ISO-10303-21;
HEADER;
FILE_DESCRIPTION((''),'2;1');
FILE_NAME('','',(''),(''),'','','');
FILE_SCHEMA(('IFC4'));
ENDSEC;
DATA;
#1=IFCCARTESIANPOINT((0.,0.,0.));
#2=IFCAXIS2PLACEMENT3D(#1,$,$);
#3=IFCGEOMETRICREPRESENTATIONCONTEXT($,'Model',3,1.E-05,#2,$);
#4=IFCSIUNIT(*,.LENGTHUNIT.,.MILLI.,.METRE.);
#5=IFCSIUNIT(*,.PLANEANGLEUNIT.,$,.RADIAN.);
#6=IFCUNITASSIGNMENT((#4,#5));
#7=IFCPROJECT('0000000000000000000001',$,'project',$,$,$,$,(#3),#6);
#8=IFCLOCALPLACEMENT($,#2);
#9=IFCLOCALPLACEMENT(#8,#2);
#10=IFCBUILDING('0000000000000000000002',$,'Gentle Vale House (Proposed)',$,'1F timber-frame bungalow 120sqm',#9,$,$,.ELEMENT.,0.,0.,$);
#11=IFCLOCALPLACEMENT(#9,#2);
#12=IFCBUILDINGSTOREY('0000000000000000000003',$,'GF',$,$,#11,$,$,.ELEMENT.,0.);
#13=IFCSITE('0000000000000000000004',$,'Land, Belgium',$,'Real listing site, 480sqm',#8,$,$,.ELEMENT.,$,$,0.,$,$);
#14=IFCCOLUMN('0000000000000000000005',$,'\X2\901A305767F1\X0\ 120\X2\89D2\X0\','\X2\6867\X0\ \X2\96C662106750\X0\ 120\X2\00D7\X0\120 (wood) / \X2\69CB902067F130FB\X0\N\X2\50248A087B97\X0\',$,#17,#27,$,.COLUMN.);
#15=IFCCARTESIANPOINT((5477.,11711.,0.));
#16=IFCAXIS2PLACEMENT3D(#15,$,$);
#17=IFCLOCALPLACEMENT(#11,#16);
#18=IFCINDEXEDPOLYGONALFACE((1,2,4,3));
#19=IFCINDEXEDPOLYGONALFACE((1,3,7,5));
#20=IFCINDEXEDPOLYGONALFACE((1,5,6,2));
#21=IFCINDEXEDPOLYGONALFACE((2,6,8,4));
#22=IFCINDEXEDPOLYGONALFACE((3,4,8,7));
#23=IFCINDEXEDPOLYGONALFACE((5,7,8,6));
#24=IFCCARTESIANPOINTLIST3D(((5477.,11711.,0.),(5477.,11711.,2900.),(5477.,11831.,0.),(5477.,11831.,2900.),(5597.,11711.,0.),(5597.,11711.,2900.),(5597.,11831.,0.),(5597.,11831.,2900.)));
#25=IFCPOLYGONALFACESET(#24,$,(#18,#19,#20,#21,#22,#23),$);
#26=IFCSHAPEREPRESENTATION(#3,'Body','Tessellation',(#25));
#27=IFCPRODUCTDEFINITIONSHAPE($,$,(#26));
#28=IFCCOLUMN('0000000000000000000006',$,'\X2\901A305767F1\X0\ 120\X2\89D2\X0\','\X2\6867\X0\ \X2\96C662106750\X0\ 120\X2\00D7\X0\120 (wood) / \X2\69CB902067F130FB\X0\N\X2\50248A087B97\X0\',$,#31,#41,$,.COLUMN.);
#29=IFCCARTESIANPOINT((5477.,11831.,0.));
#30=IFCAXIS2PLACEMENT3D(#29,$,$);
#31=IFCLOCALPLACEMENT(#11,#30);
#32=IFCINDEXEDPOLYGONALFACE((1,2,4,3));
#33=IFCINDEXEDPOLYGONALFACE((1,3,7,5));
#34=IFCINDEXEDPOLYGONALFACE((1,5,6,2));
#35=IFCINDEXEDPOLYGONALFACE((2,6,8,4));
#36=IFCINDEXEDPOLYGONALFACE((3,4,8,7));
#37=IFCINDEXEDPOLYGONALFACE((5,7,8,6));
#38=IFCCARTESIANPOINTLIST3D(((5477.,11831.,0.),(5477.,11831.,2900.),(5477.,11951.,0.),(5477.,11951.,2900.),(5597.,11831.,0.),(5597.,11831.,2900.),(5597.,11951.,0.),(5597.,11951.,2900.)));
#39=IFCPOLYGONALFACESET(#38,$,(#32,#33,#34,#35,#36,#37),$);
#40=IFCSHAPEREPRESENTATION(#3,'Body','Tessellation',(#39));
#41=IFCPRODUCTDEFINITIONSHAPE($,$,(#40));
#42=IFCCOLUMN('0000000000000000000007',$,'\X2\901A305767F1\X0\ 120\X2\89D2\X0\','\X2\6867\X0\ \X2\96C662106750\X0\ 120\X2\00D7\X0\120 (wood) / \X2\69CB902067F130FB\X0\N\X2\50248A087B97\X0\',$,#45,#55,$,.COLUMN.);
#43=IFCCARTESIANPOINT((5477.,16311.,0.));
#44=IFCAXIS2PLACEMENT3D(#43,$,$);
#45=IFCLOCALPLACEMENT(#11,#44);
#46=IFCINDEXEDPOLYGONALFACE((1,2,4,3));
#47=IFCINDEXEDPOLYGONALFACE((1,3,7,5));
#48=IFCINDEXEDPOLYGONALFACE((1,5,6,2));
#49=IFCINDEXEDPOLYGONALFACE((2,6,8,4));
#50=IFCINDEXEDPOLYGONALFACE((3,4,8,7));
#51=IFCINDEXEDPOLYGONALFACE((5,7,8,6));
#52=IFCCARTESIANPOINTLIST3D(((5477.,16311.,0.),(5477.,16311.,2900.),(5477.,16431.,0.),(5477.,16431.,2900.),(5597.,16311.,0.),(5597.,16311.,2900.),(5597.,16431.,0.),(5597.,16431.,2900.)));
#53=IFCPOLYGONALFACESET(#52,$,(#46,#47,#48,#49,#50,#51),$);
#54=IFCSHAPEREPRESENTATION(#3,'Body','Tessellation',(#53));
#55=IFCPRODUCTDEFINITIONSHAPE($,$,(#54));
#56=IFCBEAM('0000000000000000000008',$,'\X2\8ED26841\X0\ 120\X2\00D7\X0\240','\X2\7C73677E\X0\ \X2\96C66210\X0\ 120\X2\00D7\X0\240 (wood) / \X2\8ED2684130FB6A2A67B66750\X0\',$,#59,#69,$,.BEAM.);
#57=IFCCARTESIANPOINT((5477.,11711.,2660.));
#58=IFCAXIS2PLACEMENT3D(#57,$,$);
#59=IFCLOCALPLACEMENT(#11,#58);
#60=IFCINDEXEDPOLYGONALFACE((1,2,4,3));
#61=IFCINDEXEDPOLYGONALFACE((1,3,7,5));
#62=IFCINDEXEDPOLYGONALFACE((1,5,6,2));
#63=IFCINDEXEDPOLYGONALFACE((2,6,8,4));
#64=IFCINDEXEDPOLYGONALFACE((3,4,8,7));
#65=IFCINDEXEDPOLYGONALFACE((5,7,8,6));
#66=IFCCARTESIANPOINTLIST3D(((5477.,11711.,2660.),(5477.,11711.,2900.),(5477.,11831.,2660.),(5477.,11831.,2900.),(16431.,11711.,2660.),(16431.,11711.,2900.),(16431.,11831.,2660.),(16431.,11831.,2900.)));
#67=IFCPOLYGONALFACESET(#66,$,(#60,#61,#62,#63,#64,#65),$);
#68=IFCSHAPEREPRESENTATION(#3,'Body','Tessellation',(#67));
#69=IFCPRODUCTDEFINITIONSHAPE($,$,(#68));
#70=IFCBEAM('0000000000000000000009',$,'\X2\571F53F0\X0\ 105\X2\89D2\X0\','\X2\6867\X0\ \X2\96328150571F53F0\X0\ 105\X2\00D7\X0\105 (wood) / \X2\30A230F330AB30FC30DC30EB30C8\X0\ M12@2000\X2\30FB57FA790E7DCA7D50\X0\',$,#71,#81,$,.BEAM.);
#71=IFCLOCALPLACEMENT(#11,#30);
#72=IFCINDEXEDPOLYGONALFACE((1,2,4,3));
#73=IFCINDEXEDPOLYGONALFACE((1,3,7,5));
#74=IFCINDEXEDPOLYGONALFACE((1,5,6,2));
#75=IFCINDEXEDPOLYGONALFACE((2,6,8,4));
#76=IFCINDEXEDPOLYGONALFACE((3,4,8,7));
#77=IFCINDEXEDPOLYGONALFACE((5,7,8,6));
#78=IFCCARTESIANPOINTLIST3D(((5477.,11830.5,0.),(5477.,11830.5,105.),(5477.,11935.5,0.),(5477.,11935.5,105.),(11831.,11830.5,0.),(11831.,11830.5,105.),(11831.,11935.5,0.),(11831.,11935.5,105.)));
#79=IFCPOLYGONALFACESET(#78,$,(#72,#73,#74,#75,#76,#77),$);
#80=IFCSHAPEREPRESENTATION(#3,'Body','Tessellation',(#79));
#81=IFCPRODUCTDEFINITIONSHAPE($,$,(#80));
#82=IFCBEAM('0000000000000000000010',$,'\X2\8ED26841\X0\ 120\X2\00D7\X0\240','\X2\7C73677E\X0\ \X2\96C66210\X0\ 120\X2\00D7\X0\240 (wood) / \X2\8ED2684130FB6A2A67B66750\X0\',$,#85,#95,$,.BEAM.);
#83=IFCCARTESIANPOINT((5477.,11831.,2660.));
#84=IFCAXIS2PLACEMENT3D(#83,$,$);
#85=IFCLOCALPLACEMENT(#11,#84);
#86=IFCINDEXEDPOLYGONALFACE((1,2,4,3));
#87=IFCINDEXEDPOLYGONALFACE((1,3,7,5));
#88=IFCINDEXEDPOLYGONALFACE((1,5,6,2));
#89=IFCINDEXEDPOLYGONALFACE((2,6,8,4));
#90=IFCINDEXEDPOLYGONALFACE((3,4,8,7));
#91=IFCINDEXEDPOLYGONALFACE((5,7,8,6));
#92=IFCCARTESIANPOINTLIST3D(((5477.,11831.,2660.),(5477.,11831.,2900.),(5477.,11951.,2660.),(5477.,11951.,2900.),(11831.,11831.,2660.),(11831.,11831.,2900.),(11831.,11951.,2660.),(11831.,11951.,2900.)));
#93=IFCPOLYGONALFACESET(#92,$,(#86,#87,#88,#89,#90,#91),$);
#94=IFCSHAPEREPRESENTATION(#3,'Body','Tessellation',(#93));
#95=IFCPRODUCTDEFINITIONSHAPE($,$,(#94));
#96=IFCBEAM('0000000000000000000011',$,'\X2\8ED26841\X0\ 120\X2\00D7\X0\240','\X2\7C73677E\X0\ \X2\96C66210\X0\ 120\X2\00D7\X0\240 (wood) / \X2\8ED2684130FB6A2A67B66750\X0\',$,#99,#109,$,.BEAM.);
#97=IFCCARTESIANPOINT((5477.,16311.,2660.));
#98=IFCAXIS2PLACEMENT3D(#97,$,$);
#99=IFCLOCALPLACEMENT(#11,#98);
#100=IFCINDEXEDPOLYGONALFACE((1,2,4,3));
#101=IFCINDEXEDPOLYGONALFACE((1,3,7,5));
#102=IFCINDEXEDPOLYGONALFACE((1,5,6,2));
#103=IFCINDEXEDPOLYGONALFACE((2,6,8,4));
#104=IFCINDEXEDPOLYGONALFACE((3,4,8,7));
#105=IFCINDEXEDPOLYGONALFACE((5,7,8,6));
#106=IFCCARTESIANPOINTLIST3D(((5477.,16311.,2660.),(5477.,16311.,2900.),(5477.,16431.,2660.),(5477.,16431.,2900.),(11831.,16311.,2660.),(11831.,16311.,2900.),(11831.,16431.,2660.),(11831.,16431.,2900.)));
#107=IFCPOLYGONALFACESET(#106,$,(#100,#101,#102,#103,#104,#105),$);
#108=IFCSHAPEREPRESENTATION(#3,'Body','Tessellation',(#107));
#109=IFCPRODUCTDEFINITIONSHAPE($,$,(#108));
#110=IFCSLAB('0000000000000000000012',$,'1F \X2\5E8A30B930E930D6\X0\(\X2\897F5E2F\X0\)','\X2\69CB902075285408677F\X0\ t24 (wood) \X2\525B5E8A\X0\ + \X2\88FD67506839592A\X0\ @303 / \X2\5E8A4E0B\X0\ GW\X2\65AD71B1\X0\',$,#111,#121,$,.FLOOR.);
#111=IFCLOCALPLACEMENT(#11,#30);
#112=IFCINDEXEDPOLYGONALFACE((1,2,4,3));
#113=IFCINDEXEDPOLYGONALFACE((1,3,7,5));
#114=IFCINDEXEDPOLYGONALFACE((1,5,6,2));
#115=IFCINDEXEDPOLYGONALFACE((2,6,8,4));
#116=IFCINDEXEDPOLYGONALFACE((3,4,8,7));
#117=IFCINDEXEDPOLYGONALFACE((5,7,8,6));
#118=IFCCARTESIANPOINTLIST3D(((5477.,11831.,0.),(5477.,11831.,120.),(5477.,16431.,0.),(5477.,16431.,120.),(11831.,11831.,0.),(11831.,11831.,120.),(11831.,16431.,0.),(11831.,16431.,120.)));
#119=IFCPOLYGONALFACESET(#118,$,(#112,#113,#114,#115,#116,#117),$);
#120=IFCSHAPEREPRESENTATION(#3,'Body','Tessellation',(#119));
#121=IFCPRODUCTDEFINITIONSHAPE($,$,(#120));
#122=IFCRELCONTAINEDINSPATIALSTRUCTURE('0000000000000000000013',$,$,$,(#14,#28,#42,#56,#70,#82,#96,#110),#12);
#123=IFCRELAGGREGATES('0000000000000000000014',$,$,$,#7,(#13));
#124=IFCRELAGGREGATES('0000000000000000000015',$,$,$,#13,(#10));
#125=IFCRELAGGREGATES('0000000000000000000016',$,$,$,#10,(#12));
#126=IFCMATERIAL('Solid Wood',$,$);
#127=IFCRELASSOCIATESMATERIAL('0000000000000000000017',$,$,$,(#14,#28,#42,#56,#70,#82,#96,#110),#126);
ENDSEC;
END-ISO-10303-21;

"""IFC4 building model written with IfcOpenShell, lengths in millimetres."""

from ifc_helpers import new_model, si_unit, frame, frame_2d, origin, place, context, project, spatial, rectangle, extrude, material, element, save


model = new_model("IFC4")

# Units and contexts
model_context = context("Model", 3, precision=1e-05, world=origin())
ifc_project = project(units=[si_unit("LENGTHUNIT", "METRE", prefix="MILLI"), si_unit("PLANEANGLEUNIT", "RADIAN")], contexts=[model_context])

# Site, building, storey
site_placement = place(None, origin())
site = spatial("IfcSite", under=ifc_project, at=site_placement, Name="Land, Belgium", ObjectType="Real listing site, 480sqm", CompositionType="ELEMENT", RefElevation=0.0)
building_placement = place(site_placement, origin())
building = spatial("IfcBuilding", under=site, at=building_placement, Name="Gentle Vale House (Proposed)", ObjectType="1F timber-frame bungalow 120sqm", CompositionType="ELEMENT", ElevationOfRefHeight=0.0, ElevationOfTerrain=0.0)
storey_placement = place(building_placement, origin())
storey = spatial("IfcBuildingStorey", under=building, at=storey_placement, Name="GF", CompositionType="ELEMENT", Elevation=0.0)

# Columns
ifc_material_1 = material(Name="Solid Wood")
column_1_placement = place(storey_placement, frame((5477.0, 11711.0, 0.0)))
element("IfcColumn", 1, at=column_1_placement, inside=storey, material=ifc_material_1, Name="通し柱 120角", Description="桧 集成材 120×120 (wood) / 構造柱・N値計算", PredefinedType="COLUMN", context=model_context, shape_type="SweptSolid", body=[
    extrude(rectangle(XDim=120.0, YDim=120.0, at=frame_2d((60.0, 60.0))), frame((5477.0, 11711.0, 0.0)), (0.0, 0.0, 1.0), 2900.0),
])
column_2_placement = place(storey_placement, frame((5477.0, 11831.0, 0.0)))
element("IfcColumn", 2, at=column_2_placement, inside=storey, material=ifc_material_1, Name="通し柱 120角", Description="桧 集成材 120×120 (wood) / 構造柱・N値計算", PredefinedType="COLUMN", context=model_context, shape_type="SweptSolid", body=[
    extrude(rectangle(XDim=120.0, YDim=120.0, at=frame_2d((60.0, 60.0))), frame((5477.0, 11831.0, 0.0)), (0.0, 0.0, 1.0), 2900.0),
])
column_3_placement = place(storey_placement, frame((5477.0, 16311.0, 0.0)))
element("IfcColumn", 3, at=column_3_placement, inside=storey, material=ifc_material_1, Name="通し柱 120角", Description="桧 集成材 120×120 (wood) / 構造柱・N値計算", PredefinedType="COLUMN", context=model_context, shape_type="SweptSolid", body=[
    extrude(rectangle(XDim=120.0, YDim=120.0, at=frame_2d((60.0, 60.0))), frame((5477.0, 16311.0, 0.0)), (0.0, 0.0, 1.0), 2900.0),
])

# Beams
beam_1_placement = place(storey_placement, frame((5477.0, 11711.0, 2660.0)))
element("IfcBeam", 4, at=beam_1_placement, inside=storey, material=ifc_material_1, Name="軒桁 120×240", Description="米松 集成 120×240 (wood) / 軒桁・横架材", PredefinedType="BEAM", context=model_context, shape_type="SweptSolid", body=[
    extrude(rectangle(XDim=10954.0, YDim=120.0, at=frame_2d((5477.0, 60.0))), frame((5477.0, 11711.0, 2660.0)), (0.0, 0.0, 1.0), 240.0),
])
beam_2_placement = place(storey_placement, frame((5477.0, 11831.0, 0.0)))
element("IfcBeam", 5, at=beam_2_placement, inside=storey, material=ifc_material_1, Name="土台 105角", Description="桧 防腐土台 105×105 (wood) / アンカーボルト M12@2000・基礎緊結", PredefinedType="BEAM", context=model_context, shape_type="SweptSolid", body=[
    extrude(rectangle(XDim=6354.0, YDim=105.0, at=frame_2d((3177.0, 52.0))), frame((5477.0, 11831.0, 0.0)), (0.0, 0.0, 1.0), 105.0),
])
beam_3_placement = place(storey_placement, frame((5477.0, 11831.0, 2660.0)))
element("IfcBeam", 6, at=beam_3_placement, inside=storey, material=ifc_material_1, Name="軒桁 120×240", Description="米松 集成 120×240 (wood) / 軒桁・横架材", PredefinedType="BEAM", context=model_context, shape_type="SweptSolid", body=[
    extrude(rectangle(XDim=6354.0, YDim=120.0, at=frame_2d((3177.0, 60.0))), frame((5477.0, 11831.0, 2660.0)), (0.0, 0.0, 1.0), 240.0),
])
beam_4_placement = place(storey_placement, frame((5477.0, 16311.0, 2660.0)))
element("IfcBeam", 7, at=beam_4_placement, inside=storey, material=ifc_material_1, Name="軒桁 120×240", Description="米松 集成 120×240 (wood) / 軒桁・横架材", PredefinedType="BEAM", context=model_context, shape_type="SweptSolid", body=[
    extrude(rectangle(XDim=6354.0, YDim=120.0, at=frame_2d((3177.0, 60.0))), frame((5477.0, 16311.0, 2660.0)), (0.0, 0.0, 1.0), 240.0),
])

# Slab
slab_placement = place(storey_placement, frame((5477.0, 11831.0, 0.0)))
element("IfcSlab", 8, at=slab_placement, inside=storey, material=ifc_material_1, Name="1F 床スラブ(西帯)", Description="構造用合板 t24 (wood) 剛床 + 製材根太 @303 / 床下 GW断熱", PredefinedType="FLOOR", context=model_context, shape_type="SweptSolid", body=[
    extrude(rectangle(XDim=6354.0, YDim=4600.0, at=frame_2d((3177.0, 2300.0))), frame((5477.0, 11831.0, 0.0)), (0.0, 0.0, 1.0), 120.0),
])

save(model, "model.ifc")
